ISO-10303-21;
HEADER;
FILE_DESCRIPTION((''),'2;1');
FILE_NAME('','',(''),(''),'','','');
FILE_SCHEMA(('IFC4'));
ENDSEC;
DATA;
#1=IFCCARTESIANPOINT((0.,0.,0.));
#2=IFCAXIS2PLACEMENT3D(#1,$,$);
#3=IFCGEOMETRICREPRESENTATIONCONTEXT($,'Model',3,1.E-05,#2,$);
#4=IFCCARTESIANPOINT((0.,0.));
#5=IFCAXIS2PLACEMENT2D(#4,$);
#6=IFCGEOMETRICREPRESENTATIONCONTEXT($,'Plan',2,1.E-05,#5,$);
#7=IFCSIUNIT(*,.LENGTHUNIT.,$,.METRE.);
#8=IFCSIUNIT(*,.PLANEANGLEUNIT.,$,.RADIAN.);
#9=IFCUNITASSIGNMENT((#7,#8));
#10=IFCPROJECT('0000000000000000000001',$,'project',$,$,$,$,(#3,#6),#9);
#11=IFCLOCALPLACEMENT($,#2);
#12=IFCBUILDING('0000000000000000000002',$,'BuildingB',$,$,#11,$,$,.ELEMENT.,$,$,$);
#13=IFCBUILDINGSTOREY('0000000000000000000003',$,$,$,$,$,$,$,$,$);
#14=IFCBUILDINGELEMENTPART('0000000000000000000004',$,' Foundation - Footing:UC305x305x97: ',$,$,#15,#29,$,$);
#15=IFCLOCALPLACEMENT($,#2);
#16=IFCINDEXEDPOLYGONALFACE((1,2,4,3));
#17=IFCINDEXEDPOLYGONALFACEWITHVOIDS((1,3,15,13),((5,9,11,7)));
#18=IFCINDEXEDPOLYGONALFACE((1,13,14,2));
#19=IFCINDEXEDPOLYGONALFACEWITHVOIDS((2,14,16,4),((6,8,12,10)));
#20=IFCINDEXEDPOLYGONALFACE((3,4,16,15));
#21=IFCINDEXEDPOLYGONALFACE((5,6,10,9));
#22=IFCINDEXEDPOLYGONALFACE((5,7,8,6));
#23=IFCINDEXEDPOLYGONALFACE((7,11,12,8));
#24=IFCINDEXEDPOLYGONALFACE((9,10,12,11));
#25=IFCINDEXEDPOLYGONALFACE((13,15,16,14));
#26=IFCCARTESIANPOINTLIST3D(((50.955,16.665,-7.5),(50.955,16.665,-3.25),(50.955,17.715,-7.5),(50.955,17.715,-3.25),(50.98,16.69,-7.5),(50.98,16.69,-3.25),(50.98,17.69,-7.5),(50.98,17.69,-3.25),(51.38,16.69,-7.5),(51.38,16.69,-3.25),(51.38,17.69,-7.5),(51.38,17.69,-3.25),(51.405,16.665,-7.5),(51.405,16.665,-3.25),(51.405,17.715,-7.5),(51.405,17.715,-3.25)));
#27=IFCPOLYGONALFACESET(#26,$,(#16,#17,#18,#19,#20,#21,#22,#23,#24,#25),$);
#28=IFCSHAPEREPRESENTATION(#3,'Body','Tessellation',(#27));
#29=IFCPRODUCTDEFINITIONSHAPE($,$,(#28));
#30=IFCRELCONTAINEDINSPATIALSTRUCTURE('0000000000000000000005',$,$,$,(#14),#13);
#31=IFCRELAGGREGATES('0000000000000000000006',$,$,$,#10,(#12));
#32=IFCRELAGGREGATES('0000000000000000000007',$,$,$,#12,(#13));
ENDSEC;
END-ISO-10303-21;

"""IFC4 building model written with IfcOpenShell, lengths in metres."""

from ifc_helpers import new_model, si_unit, origin, origin_2d, place, context, project, spatial, polyline, outline, extrude, element, save


model = new_model("IFC4")

# Units and contexts
model_context = context("Model", 3, precision=1e-05, world=origin())
plan_context = context("Plan", 2, precision=1e-05, world=origin_2d())
ifc_project = project(units=[si_unit("LENGTHUNIT", "METRE"), si_unit("PLANEANGLEUNIT", "RADIAN")], contexts=[model_context, plan_context])

# Building, storey
building_placement = place(None, origin())
building = spatial("IfcBuilding", under=ifc_project, at=building_placement, Name="BuildingB", CompositionType="ELEMENT")
storey = spatial("IfcBuildingStorey", under=building)

# Building element part, opening
building_element_part_1 = element("IfcBuildingElementPart", 1, inside=storey, Name=" Foundation - Footing:UC305x305x97: ", context=model_context, shape_type="SweptSolid", body=[
    extrude(outline(polyline([(51.405, 17.715, -7.5), (50.955, 17.715, -7.5), (50.955, 16.665, -7.5), (51.405, 16.665, -7.5), (51.405, 17.715, -7.5)])), None, (0.0, 0.0, 1.0), 4.25),
])
element("IfcOpeningElement", 2, inside=storey, cuts=building_element_part_1, context=model_context, shape_type="SweptSolid", body=[
    extrude(outline(polyline([(51.38, 17.69, -7.5), (50.98, 17.69, -7.5), (50.98, 16.69, -7.5), (51.38, 16.69, -7.5), (51.38, 17.69, -7.5)])), None, (0.0, 0.0, 1.0), 4.25),
])

save(model, "model.ifc")
